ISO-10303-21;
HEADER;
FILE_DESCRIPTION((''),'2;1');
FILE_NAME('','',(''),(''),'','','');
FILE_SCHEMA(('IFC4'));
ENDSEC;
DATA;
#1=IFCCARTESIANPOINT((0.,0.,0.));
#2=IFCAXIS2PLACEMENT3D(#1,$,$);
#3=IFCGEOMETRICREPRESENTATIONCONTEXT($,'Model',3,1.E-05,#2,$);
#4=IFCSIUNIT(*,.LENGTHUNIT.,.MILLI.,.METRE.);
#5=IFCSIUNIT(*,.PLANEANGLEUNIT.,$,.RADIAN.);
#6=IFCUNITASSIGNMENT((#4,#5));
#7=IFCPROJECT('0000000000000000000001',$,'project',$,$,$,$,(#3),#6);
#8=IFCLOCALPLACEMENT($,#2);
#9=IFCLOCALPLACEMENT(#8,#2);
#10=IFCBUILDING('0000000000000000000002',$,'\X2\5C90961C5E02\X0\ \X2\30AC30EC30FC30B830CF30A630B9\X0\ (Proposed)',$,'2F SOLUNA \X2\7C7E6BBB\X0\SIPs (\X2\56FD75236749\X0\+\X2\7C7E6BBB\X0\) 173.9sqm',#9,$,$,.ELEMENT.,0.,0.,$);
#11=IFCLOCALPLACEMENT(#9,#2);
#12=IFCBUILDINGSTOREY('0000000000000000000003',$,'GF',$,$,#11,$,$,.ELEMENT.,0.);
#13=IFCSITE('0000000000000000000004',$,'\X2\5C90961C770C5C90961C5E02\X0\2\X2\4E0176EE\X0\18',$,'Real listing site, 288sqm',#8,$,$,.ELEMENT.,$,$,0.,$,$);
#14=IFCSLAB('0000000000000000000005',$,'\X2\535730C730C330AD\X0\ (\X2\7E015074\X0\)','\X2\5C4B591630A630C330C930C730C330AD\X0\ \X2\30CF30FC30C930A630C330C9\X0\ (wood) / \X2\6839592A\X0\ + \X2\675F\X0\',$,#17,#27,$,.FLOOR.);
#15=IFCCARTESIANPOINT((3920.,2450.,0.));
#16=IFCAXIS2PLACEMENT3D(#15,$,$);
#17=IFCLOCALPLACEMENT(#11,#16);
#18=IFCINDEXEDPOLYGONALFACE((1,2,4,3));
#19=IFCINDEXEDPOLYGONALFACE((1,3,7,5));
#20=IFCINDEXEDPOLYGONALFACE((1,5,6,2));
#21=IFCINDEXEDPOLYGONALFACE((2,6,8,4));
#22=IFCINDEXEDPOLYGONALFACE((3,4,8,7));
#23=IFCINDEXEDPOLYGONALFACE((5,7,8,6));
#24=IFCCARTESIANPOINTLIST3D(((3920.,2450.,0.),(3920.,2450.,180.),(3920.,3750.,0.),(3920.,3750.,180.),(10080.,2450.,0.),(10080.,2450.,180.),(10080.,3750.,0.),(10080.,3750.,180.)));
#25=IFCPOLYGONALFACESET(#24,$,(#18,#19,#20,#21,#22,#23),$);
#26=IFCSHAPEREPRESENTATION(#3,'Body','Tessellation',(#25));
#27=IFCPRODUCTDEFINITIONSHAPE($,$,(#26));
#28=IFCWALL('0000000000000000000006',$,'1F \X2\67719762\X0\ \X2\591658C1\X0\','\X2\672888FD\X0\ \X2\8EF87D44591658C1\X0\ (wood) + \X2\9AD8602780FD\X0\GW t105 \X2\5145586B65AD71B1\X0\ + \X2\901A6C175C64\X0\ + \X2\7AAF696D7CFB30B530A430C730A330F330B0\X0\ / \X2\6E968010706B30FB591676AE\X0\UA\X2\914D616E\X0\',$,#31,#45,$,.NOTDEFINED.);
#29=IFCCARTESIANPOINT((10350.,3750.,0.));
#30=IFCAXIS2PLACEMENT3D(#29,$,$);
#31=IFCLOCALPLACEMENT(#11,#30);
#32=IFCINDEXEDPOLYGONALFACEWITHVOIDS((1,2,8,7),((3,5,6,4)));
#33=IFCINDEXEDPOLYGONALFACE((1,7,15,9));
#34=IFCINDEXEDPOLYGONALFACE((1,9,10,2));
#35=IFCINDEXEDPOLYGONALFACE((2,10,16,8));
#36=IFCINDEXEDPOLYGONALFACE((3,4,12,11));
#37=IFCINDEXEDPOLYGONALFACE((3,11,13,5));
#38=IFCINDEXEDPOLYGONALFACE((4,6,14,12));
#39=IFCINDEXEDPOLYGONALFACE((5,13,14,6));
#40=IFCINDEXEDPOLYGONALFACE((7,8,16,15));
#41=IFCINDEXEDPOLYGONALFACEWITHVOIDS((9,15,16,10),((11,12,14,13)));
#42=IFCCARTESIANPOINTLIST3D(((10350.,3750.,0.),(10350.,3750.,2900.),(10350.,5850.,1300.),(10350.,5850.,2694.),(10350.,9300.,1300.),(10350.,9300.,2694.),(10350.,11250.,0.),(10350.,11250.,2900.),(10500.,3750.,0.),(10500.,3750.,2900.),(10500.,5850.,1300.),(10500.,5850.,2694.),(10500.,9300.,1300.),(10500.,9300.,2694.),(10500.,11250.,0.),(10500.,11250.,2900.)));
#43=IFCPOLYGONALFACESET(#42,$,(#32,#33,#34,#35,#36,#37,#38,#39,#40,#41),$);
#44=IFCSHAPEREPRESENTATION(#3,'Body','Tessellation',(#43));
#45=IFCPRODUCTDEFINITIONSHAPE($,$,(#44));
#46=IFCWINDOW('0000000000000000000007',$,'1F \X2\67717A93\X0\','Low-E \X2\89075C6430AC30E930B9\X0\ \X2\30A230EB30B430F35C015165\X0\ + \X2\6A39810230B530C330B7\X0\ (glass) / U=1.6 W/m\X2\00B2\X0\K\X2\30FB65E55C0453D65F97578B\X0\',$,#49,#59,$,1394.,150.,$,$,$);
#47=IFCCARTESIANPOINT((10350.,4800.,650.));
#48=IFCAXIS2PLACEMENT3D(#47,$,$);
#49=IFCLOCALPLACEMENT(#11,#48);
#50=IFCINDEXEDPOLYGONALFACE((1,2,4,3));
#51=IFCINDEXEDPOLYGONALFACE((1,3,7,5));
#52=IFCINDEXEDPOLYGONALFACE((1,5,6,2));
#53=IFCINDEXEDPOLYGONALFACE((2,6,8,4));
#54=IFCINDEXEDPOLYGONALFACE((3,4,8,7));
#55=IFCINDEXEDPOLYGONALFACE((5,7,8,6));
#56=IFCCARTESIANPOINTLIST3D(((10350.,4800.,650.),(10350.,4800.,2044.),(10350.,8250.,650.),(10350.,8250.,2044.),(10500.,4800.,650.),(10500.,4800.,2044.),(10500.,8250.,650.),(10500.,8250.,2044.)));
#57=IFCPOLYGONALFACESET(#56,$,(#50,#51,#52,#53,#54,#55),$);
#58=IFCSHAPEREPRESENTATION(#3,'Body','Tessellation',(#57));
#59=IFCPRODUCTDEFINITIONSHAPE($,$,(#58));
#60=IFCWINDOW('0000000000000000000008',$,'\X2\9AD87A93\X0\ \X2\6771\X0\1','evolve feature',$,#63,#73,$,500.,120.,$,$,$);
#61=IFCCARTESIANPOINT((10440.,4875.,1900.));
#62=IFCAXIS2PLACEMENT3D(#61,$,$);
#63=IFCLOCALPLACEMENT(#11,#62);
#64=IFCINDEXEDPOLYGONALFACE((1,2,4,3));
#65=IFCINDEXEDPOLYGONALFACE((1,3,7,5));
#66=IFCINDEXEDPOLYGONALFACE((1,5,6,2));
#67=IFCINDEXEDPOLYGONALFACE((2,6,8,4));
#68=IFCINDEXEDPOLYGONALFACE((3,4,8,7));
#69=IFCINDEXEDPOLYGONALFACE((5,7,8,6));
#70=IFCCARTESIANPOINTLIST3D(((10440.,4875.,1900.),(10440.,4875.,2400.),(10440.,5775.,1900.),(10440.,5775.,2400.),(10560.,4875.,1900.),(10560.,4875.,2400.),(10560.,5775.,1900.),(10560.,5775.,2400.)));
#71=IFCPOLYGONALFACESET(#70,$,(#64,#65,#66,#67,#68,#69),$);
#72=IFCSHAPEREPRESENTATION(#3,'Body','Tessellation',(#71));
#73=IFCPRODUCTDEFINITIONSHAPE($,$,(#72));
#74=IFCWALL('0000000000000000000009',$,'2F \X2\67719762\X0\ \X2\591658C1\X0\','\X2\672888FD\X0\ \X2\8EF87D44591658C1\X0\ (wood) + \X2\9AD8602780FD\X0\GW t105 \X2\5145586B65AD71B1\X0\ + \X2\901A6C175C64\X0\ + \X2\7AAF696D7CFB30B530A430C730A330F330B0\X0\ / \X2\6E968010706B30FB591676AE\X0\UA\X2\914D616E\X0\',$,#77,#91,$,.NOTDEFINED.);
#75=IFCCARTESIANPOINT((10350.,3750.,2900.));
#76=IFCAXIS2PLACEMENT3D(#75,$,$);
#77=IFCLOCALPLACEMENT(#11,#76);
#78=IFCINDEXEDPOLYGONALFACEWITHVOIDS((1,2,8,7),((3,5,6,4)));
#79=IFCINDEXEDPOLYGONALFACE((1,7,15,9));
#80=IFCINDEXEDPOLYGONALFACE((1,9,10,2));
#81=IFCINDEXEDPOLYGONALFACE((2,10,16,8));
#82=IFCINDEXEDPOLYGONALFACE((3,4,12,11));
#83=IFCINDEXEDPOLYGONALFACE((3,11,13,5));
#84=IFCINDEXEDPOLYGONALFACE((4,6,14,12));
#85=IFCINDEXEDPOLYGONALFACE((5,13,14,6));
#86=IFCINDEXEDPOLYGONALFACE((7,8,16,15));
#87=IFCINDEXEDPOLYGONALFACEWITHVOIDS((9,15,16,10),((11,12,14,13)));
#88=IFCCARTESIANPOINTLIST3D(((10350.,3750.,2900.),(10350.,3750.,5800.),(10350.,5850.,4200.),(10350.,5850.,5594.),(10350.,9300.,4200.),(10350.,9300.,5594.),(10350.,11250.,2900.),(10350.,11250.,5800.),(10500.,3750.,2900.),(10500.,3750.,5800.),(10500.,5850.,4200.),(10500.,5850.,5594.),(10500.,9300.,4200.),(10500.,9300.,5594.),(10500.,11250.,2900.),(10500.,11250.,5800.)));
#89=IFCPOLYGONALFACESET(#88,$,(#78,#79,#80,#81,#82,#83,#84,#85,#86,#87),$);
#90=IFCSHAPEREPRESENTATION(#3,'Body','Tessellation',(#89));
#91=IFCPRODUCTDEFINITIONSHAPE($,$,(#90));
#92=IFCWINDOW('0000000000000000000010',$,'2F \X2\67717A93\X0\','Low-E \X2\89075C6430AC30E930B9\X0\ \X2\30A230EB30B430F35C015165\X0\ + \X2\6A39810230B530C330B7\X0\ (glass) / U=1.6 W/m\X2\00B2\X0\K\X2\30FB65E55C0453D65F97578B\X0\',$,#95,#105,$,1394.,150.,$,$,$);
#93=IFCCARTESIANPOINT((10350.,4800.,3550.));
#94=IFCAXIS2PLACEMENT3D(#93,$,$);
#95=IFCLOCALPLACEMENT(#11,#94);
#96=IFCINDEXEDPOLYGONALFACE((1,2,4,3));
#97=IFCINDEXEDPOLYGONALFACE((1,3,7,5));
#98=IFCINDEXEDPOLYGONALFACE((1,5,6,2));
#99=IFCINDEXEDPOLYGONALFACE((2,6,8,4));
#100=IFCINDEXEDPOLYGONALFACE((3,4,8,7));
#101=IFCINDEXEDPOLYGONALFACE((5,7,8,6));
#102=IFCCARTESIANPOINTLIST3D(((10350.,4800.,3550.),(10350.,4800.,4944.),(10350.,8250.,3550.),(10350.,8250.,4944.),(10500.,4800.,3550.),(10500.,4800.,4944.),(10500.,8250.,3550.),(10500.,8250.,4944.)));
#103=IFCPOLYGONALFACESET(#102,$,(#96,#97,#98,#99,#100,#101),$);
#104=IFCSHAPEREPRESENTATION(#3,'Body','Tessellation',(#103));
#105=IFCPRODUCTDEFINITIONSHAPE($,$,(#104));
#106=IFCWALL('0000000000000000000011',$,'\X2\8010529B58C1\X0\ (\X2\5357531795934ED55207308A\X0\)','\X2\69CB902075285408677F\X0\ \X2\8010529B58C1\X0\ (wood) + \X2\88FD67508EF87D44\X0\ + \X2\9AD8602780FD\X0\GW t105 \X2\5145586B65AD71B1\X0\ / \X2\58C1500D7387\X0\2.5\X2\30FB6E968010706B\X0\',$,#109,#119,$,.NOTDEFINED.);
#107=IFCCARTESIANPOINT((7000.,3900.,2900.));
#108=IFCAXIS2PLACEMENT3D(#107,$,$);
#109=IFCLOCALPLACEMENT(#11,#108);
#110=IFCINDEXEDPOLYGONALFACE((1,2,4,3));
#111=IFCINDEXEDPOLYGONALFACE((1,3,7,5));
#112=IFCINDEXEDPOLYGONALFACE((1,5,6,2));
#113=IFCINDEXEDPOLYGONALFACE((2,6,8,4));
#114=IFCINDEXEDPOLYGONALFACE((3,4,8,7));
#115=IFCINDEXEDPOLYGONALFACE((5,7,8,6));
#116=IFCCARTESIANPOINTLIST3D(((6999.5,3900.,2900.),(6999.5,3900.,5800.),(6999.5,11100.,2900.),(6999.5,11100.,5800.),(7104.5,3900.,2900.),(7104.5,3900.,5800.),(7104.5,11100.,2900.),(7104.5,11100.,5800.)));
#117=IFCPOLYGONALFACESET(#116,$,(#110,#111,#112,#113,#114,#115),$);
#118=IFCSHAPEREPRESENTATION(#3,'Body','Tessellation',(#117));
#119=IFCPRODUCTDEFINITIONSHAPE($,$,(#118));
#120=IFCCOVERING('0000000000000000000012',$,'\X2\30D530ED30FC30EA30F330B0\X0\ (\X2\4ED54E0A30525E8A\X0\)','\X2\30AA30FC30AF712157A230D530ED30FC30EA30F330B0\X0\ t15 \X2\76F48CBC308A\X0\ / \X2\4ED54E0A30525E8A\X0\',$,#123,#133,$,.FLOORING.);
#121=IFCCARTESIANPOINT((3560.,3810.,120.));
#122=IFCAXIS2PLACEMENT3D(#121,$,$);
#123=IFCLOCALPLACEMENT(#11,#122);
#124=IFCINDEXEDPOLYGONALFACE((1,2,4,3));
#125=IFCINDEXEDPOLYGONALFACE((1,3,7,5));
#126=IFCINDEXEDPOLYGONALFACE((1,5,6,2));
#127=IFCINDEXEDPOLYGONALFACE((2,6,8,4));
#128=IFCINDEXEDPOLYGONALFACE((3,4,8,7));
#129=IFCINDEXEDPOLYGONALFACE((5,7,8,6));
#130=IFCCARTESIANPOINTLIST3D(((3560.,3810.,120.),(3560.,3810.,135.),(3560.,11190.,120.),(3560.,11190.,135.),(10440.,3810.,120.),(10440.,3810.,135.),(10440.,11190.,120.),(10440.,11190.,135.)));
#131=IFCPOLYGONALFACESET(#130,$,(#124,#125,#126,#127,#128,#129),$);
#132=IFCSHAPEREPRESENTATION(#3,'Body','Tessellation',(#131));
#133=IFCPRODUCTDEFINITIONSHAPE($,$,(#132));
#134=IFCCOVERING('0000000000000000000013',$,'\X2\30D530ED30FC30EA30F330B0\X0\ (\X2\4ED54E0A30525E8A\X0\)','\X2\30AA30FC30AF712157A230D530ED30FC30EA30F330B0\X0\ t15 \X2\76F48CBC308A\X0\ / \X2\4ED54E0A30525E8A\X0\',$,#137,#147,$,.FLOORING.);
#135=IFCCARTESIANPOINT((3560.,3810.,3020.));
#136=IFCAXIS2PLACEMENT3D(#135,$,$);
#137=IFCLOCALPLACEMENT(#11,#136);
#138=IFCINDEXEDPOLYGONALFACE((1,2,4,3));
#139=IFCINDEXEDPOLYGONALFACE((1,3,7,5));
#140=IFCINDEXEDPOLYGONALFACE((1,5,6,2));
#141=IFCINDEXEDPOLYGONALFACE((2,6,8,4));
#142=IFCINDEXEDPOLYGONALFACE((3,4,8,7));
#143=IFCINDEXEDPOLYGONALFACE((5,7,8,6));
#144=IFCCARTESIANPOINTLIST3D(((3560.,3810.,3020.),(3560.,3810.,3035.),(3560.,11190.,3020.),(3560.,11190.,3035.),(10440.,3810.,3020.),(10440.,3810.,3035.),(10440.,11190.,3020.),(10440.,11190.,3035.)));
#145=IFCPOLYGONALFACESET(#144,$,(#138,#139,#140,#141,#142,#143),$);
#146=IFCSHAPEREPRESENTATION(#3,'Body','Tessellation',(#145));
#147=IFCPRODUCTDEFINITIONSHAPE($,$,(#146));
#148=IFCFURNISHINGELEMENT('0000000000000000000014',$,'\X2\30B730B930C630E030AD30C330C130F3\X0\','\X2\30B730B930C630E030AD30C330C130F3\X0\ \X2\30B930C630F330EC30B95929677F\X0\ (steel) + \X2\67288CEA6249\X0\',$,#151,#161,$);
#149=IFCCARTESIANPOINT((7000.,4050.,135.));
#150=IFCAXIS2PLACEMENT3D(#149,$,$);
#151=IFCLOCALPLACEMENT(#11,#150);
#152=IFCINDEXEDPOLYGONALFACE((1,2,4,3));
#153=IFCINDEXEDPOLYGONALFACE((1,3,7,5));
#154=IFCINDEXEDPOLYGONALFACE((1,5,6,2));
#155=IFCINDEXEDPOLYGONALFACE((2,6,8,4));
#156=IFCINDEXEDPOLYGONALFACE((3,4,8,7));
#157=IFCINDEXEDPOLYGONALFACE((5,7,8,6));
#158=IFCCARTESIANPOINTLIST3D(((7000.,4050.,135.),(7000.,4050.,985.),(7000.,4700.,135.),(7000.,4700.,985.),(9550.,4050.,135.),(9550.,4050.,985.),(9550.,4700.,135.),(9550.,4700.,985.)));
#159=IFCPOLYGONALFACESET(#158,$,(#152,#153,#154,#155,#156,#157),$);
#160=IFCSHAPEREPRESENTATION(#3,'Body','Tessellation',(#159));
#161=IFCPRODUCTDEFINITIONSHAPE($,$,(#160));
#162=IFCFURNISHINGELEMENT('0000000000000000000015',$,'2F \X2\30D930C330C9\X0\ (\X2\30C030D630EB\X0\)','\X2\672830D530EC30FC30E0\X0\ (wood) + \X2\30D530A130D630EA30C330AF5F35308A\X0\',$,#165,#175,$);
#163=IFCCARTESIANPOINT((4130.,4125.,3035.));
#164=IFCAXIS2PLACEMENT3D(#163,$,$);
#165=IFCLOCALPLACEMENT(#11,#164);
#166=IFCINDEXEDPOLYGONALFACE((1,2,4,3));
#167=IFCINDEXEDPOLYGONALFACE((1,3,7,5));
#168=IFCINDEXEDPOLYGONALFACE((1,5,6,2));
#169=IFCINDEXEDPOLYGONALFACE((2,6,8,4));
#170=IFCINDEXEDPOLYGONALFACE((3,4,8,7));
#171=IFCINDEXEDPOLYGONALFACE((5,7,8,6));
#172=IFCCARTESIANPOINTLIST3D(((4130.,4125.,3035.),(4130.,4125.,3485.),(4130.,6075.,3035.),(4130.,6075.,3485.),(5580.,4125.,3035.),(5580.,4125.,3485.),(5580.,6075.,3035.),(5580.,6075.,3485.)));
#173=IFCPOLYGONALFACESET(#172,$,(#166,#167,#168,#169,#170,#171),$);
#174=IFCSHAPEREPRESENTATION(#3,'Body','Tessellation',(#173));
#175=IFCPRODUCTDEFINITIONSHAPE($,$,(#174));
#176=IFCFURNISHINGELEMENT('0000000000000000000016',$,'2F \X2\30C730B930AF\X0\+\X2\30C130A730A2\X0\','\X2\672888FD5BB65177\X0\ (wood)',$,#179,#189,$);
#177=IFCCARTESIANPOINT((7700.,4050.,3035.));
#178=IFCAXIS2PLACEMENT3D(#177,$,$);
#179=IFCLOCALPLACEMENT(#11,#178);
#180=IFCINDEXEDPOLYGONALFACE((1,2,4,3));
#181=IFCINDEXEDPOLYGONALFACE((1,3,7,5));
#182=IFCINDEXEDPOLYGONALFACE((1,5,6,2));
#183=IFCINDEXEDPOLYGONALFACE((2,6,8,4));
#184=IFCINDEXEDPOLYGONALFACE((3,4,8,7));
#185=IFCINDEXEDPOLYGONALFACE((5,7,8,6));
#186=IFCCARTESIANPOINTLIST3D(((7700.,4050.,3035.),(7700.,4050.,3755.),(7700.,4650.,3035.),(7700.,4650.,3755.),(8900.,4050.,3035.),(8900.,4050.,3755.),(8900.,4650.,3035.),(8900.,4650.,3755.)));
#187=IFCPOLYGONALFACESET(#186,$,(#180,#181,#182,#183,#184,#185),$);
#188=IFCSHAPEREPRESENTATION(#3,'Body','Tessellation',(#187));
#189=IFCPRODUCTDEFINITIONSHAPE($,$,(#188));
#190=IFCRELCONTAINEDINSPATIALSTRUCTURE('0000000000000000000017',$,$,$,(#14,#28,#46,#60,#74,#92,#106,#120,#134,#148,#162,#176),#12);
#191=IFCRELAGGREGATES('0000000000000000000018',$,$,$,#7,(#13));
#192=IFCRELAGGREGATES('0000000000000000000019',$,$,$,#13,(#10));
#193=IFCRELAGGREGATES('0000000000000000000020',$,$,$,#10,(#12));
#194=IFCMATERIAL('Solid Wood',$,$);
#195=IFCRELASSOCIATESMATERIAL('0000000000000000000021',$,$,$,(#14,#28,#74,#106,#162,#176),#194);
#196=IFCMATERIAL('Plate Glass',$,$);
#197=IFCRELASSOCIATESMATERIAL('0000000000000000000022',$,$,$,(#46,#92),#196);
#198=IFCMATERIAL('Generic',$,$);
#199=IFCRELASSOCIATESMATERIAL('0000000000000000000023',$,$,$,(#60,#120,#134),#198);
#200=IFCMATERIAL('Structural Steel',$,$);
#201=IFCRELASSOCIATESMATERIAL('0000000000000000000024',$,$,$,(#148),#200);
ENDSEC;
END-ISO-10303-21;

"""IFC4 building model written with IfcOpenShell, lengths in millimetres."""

from ifc_helpers import new_model, si_unit, frame, frame_2d, origin, place, context, project, spatial, rectangle, extrude, material, element, fill, save


model = new_model("IFC4")

# Units and contexts
model_context = context("Model", 3, precision=1e-05, world=origin())
ifc_project = project(units=[si_unit("LENGTHUNIT", "METRE", prefix="MILLI"), si_unit("PLANEANGLEUNIT", "RADIAN")], contexts=[model_context])

# Site, building, storey
site_placement = place(None, origin())
site = spatial("IfcSite", under=ifc_project, at=site_placement, Name="岐阜県岐阜市2丁目18", ObjectType="Real listing site, 288sqm", CompositionType="ELEMENT", RefElevation=0.0)
building_placement = place(site_placement, origin())
building = spatial("IfcBuilding", under=site, at=building_placement, Name="岐阜市 ガレージハウス (Proposed)", ObjectType="2F SOLUNA 籾殻SIPs (国産杉+籾殻) 173.9sqm", CompositionType="ELEMENT", ElevationOfRefHeight=0.0, ElevationOfTerrain=0.0)
storey_placement = place(building_placement, origin())
storey = spatial("IfcBuildingStorey", under=building, at=storey_placement, Name="GF", CompositionType="ELEMENT", Elevation=0.0)

# Slab
ifc_material_1 = material(Name="Solid Wood")
slab_placement = place(storey_placement, frame((3920.0, 2450.0, 0.0)))
element("IfcSlab", 1, at=slab_placement, inside=storey, material=ifc_material_1, Name="南デッキ (縁側)", Description="屋外ウッドデッキ ハードウッド (wood) / 根太 + 束", PredefinedType="FLOOR", context=model_context, shape_type="SweptSolid", body=[
    extrude(rectangle(XDim=6160.0, YDim=1300.0, at=frame_2d((3080.0, 650.0))), frame((3920.0, 2450.0, 0.0)), (0.0, 0.0, 1.0), 180.0),
])

# Wall, openings, windows
wall_1_placement = place(storey_placement, frame((10350.0, 3750.0, 0.0)))
wall_1 = element("IfcWall", 2, at=wall_1_placement, inside=storey, material=ifc_material_1, Name="1F 東面 外壁", Description="木製 軸組外壁 (wood) + 高性能GW t105 充填断熱 + 通気層 + 窯業系サイディング / 準耐火・外皮UA配慮", PredefinedType="NOTDEFINED", context=model_context, shape_type="SweptSolid", body=[
    extrude(rectangle(XDim=150.0, YDim=7500.0, at=frame_2d((75.0, 3750.0))), frame((10350.0, 3750.0, 0.0)), (0.0, 0.0, 1.0), 2900.0),
])
opening_1_placement = place(storey_placement, frame((10350.0, 4800.0, 650.0)))
opening_1 = element("IfcOpeningElement", 3, at=opening_1_placement, cuts=wall_1, PredefinedType="NOTDEFINED", context=model_context, shape_type="SweptSolid", body=[
    extrude(rectangle(XDim=150.0, YDim=3450.0, at=frame_2d((75.0, 1725.0))), frame((10350.0, 4800.0, 650.0)), (0.0, 0.0, 1.0), 1394.0),
])
opening_2_placement = place(storey_placement, frame((10440.0, 4875.0, 1900.0)))
opening_2 = element("IfcOpeningElement", 4, at=opening_2_placement, cuts=wall_1, PredefinedType="NOTDEFINED", context=model_context, shape_type="SweptSolid", body=[
    extrude(rectangle(XDim=120.0, YDim=900.0, at=frame_2d((60.0, 450.0))), frame((10440.0, 4875.0, 1900.0)), (0.0, 0.0, 1.0), 500.0),
])
ifc_material_2 = material(Name="Plate Glass")
window_1_placement = place(storey_placement, frame((10350.0, 4800.0, 650.0)))
window_1 = element("IfcWindow", 5, at=window_1_placement, inside=storey, material=ifc_material_2, Name="1F 東窓", Description="Low-E 複層ガラス アルゴン封入 + 樹脂サッシ (glass) / U=1.6 W/m²K・日射取得型", OverallHeight=1394.0, OverallWidth=150.0, context=model_context, shape_type="SweptSolid", body=[
    extrude(rectangle(XDim=150.0, YDim=3450.0, at=frame_2d((75.0, 1725.0))), frame((10350.0, 4800.0, 650.0)), (0.0, 0.0, 1.0), 1394.0),
])
fill(opening_1, window_1)
ifc_material_3 = material(Name="Generic")
window_2_placement = place(storey_placement, frame((10440.0, 4875.0, 1900.0)))
window_2 = element("IfcWindow", 6, at=window_2_placement, inside=storey, material=ifc_material_3, Name="高窓 東1", Description="evolve feature", OverallHeight=500.0, OverallWidth=120.0, context=model_context, shape_type="SweptSolid", body=[
    extrude(rectangle(XDim=120.0, YDim=900.0, at=frame_2d((60.0, 450.0))), frame((10440.0, 4875.0, 1900.0)), (0.0, 0.0, 1.0), 500.0),
])
fill(opening_2, window_2)

# Wall, opening, window
wall_2_placement = place(storey_placement, frame((10350.0, 3750.0, 2900.0)))
wall_2 = element("IfcWall", 7, at=wall_2_placement, inside=storey, material=ifc_material_1, Name="2F 東面 外壁", Description="木製 軸組外壁 (wood) + 高性能GW t105 充填断熱 + 通気層 + 窯業系サイディング / 準耐火・外皮UA配慮", PredefinedType="NOTDEFINED", context=model_context, shape_type="SweptSolid", body=[
    extrude(rectangle(XDim=150.0, YDim=7500.0, at=frame_2d((75.0, 3750.0))), frame((10350.0, 3750.0, 2900.0)), (0.0, 0.0, 1.0), 2900.0),
])
opening_3_placement = place(storey_placement, frame((10350.0, 4800.0, 3550.0)))
opening_3 = element("IfcOpeningElement", 8, at=opening_3_placement, cuts=wall_2, PredefinedType="NOTDEFINED", context=model_context, shape_type="SweptSolid", body=[
    extrude(rectangle(XDim=150.0, YDim=3450.0, at=frame_2d((75.0, 1725.0))), frame((10350.0, 4800.0, 3550.0)), (0.0, 0.0, 1.0), 1394.0),
])
window_3_placement = place(storey_placement, frame((10350.0, 4800.0, 3550.0)))
window_3 = element("IfcWindow", 9, at=window_3_placement, inside=storey, material=ifc_material_2, Name="2F 東窓", Description="Low-E 複層ガラス アルゴン封入 + 樹脂サッシ (glass) / U=1.6 W/m²K・日射取得型", OverallHeight=1394.0, OverallWidth=150.0, context=model_context, shape_type="SweptSolid", body=[
    extrude(rectangle(XDim=150.0, YDim=3450.0, at=frame_2d((75.0, 1725.0))), frame((10350.0, 4800.0, 3550.0)), (0.0, 0.0, 1.0), 1394.0),
])
fill(opening_3, window_3)

# Wall
wall_3_placement = place(storey_placement, frame((7000.0, 3900.0, 2900.0)))
element("IfcWall", 10, at=wall_3_placement, inside=storey, material=ifc_material_1, Name="耐力壁 (南北間仕切り)", Description="構造用合板 耐力壁 (wood) + 製材軸組 + 高性能GW t105 充填断熱 / 壁倍率2.5・準耐火", PredefinedType="NOTDEFINED", context=model_context, shape_type="SweptSolid", body=[
    extrude(rectangle(XDim=105.0, YDim=7200.0, at=frame_2d((52.0, 3600.0))), frame((7000.0, 3900.0, 2900.0)), (0.0, 0.0, 1.0), 2900.0),
])

# Coverings
covering_1_placement = place(storey_placement, frame((3560.0, 3810.0, 120.0)))
element("IfcCovering", 11, at=covering_1_placement, inside=storey, material=ifc_material_3, Name="フローリング (仕上げ床)", Description="オーク無垢フローリング t15 直貼り / 仕上げ床", PredefinedType="FLOORING", context=model_context, shape_type="SweptSolid", body=[
    extrude(rectangle(XDim=6880.0, YDim=7380.0, at=frame_2d((3440.0, 3690.0))), frame((3560.0, 3810.0, 120.0)), (0.0, 0.0, 1.0), 15.0),
])
covering_2_placement = place(storey_placement, frame((3560.0, 3810.0, 3020.0)))
element("IfcCovering", 12, at=covering_2_placement, inside=storey, material=ifc_material_3, Name="フローリング (仕上げ床)", Description="オーク無垢フローリング t15 直貼り / 仕上げ床", PredefinedType="FLOORING", context=model_context, shape_type="SweptSolid", body=[
    extrude(rectangle(XDim=6880.0, YDim=7380.0, at=frame_2d((3440.0, 3690.0))), frame((3560.0, 3810.0, 3020.0)), (0.0, 0.0, 1.0), 15.0),
])

# Furnishing elements
ifc_material_4 = material(Name="Structural Steel")
furnishing_1_placement = place(storey_placement, frame((7000.0, 4050.0, 135.0)))
element("IfcFurnishingElement", 13, at=furnishing_1_placement, inside=storey, material=ifc_material_4, Name="システムキッチン", Description="システムキッチン ステンレス天板 (steel) + 木質扉", context=model_context, shape_type="SweptSolid", body=[
    extrude(rectangle(XDim=2550.0, YDim=650.0, at=frame_2d((1275.0, 325.0))), frame((7000.0, 4050.0, 135.0)), (0.0, 0.0, 1.0), 850.0),
])
furnishing_2_placement = place(storey_placement, frame((4130.0, 4125.0, 3035.0)))
element("IfcFurnishingElement", 14, at=furnishing_2_placement, inside=storey, material=ifc_material_1, Name="2F ベッド (ダブル)", Description="木フレーム (wood) + ファブリック張り", context=model_context, shape_type="SweptSolid", body=[
    extrude(rectangle(XDim=1450.0, YDim=1950.0, at=frame_2d((725.0, 975.0))), frame((4130.0, 4125.0, 3035.0)), (0.0, 0.0, 1.0), 450.0),
])
furnishing_3_placement = place(storey_placement, frame((7700.0, 4050.0, 3035.0)))
element("IfcFurnishingElement", 15, at=furnishing_3_placement, inside=storey, material=ifc_material_1, Name="2F デスク+チェア", Description="木製家具 (wood)", context=model_context, shape_type="SweptSolid", body=[
    extrude(rectangle(XDim=1200.0, YDim=600.0, at=frame_2d((600.0, 300.0))), frame((7700.0, 4050.0, 3035.0)), (0.0, 0.0, 1.0), 720.0),
])

save(model, "model.ifc")
